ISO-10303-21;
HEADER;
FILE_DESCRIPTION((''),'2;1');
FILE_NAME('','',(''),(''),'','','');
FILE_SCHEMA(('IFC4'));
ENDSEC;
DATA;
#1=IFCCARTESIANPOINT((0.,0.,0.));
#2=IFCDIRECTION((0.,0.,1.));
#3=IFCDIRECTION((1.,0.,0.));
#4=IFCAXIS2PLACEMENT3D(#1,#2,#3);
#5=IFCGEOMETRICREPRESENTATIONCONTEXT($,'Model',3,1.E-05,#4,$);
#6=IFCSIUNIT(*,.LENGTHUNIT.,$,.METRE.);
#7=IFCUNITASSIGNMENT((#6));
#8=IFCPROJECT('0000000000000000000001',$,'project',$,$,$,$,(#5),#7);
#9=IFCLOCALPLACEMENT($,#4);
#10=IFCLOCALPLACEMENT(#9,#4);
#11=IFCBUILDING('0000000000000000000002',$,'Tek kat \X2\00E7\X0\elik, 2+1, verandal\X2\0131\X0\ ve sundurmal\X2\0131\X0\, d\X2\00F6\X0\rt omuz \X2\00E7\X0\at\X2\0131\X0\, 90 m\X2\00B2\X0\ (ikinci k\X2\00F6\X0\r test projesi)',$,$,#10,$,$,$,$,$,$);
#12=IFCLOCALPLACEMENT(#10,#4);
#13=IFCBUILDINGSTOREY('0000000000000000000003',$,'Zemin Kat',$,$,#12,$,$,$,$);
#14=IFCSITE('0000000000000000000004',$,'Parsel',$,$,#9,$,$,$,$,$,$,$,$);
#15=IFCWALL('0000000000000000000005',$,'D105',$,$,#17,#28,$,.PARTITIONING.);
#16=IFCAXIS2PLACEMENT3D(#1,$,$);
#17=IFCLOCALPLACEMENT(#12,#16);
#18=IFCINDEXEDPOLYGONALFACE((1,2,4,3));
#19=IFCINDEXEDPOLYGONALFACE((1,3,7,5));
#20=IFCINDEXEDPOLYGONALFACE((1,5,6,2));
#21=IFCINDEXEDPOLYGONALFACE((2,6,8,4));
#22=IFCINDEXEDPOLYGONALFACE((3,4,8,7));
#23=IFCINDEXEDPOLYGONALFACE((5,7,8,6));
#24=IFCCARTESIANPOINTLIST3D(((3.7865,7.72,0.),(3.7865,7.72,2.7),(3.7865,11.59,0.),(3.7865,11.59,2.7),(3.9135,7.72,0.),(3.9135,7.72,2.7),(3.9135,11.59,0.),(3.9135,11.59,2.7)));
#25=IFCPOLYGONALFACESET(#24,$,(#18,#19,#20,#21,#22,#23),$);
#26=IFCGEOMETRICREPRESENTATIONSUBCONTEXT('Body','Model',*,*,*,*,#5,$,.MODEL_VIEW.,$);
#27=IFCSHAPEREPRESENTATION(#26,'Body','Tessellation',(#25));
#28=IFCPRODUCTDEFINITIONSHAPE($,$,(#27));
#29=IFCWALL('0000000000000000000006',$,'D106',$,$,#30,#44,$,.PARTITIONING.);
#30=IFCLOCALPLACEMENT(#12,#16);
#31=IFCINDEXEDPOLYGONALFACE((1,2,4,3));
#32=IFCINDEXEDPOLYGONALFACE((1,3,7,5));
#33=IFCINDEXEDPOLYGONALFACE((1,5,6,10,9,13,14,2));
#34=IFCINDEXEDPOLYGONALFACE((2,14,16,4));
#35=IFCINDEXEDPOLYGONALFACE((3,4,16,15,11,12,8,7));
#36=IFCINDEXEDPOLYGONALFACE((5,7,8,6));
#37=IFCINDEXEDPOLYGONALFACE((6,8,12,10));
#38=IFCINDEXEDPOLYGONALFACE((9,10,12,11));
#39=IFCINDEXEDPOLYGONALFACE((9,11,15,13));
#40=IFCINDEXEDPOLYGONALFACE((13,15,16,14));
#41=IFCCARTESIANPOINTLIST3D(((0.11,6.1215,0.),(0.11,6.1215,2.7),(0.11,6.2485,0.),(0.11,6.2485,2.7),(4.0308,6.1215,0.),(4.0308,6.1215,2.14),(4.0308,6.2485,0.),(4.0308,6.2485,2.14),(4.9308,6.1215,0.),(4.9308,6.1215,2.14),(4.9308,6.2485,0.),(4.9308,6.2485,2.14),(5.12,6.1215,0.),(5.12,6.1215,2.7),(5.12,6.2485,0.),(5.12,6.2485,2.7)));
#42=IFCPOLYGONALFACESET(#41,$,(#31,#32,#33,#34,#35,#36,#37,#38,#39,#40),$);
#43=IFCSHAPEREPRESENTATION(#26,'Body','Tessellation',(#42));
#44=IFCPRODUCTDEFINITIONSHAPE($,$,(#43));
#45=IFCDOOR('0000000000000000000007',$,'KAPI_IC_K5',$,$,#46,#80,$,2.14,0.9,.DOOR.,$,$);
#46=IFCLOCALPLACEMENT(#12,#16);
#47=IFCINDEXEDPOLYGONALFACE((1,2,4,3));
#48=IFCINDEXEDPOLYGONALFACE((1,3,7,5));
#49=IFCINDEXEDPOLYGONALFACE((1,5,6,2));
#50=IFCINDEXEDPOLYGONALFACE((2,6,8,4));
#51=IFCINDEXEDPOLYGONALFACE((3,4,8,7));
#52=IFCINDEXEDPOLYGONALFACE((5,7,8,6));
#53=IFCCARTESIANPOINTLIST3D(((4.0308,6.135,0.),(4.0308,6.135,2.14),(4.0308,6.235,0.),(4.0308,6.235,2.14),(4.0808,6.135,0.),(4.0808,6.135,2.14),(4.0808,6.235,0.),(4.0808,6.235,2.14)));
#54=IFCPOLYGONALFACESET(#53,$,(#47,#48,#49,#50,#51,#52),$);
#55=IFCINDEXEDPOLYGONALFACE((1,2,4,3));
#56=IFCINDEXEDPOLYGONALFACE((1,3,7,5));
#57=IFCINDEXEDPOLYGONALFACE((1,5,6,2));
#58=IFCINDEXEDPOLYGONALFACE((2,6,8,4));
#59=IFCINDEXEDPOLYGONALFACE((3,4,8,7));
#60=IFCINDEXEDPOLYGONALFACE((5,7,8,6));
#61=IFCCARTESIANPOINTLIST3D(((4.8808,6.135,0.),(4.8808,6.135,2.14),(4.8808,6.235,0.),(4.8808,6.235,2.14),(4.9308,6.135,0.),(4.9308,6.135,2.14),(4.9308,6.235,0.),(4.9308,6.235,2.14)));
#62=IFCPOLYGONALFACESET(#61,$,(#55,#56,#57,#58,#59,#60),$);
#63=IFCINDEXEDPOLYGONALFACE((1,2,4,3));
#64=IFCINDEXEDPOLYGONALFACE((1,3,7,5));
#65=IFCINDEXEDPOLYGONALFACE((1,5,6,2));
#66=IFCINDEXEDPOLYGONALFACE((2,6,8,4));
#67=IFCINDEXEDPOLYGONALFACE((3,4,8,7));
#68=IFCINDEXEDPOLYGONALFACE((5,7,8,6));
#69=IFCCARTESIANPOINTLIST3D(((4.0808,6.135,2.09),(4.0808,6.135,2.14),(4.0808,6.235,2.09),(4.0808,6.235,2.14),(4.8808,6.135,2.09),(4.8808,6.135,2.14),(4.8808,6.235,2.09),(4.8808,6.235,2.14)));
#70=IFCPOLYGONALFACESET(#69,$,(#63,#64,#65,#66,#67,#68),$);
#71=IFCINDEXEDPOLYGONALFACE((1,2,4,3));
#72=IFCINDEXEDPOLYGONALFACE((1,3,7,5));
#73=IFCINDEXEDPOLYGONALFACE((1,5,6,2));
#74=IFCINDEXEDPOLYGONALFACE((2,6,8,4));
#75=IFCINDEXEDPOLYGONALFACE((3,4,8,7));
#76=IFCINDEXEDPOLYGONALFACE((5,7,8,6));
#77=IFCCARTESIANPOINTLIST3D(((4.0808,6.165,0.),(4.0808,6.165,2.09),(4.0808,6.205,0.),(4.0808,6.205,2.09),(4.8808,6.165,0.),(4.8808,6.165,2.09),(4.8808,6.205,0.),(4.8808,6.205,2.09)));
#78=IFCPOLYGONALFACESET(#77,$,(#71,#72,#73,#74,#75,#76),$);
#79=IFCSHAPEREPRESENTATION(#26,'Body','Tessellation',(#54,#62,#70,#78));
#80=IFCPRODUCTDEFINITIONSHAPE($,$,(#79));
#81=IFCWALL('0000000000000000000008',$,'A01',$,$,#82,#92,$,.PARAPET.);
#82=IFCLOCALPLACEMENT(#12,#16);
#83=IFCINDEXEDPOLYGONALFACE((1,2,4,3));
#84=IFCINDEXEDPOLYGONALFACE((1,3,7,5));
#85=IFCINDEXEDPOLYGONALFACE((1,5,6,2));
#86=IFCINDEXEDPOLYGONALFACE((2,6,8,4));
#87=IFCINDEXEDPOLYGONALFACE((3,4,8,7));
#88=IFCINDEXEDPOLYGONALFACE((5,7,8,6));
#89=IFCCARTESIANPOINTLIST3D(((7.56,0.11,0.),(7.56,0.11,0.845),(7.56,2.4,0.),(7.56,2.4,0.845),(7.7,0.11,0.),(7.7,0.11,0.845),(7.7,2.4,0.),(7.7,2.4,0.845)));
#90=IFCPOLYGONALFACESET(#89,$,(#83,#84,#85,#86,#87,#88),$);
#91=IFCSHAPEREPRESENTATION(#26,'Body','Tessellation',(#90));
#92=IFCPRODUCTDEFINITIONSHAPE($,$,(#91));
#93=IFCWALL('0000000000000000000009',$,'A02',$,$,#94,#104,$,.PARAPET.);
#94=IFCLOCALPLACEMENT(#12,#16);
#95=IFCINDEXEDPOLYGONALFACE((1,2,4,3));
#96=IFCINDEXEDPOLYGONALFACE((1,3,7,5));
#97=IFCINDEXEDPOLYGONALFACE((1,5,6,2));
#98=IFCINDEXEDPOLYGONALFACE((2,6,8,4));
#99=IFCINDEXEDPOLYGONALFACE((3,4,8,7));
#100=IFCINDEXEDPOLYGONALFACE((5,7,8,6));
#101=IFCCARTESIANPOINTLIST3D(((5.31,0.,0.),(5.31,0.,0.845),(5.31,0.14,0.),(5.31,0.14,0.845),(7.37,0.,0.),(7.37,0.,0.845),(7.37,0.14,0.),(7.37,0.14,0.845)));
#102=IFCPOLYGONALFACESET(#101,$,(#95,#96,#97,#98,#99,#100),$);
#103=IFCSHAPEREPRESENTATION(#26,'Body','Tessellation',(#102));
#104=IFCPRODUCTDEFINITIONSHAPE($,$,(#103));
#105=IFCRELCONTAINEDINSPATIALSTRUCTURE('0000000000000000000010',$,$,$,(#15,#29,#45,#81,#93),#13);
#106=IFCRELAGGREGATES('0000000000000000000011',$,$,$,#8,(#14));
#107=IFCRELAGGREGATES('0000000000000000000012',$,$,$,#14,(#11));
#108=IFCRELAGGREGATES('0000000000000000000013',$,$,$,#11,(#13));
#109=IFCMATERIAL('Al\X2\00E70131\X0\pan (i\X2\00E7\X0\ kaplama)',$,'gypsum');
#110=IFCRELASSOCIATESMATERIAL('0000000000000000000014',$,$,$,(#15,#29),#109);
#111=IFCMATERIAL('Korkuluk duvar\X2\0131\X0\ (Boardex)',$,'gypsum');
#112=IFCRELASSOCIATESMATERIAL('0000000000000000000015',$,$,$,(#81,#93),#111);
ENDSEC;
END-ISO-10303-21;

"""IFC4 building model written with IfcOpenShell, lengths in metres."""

from ifc_helpers import new_model, si_unit, frame, origin_with_axes, place, context, subcontext, project, spatial, line, indexed_curve, outline, extrude, material, element, fill, save


model = new_model("IFC4")

# Units and contexts
model_context = context("Model", 3, precision=1e-05, world=origin_with_axes())
body_context = subcontext(model_context, "Body", "Model", "MODEL_VIEW")
ifc_project = project(units=[si_unit("LENGTHUNIT", "METRE")], contexts=[model_context])

# Site, building, storey
site_placement = place(None, origin_with_axes())
site = spatial("IfcSite", under=ifc_project, at=site_placement, Name="Parsel")
building_placement = place(site_placement, origin_with_axes())
building = spatial("IfcBuilding", under=site, at=building_placement, Name="Tek kat çelik, 2+1, verandalı ve sundurmalı, dört omuz çatı, 90 m² (ikinci kör test projesi)")
storey_placement = place(building_placement, origin_with_axes())
storey = spatial("IfcBuildingStorey", under=building, at=storey_placement, Name="Zemin Kat")

# Shared definitions
ifc_material_1 = material(Name="Alçıpan (iç kaplama)", Category="gypsum")

# Wall
wall_1_placement = place(storey_placement, origin_with_axes())
element("IfcWall", 1, at=wall_1_placement, inside=storey, material=ifc_material_1, Name="D105", PredefinedType="PARTITIONING", context=body_context, shape_type="SweptSolid", body=[
    extrude(outline(indexed_curve([(0.0, 0.0), (0.127, 0.0), (0.127, 3.87), (0.0, 3.87)], segments=[line(1, 2, 3, 4, 1)])), frame((3.7865, 7.72, 0.0), z_axis=(0.0, 0.0, 1.0), x_axis=(1.0, 0.0, 0.0)), (0.0, 0.0, 1.0), 2.7),
])

# Wall, opening, door
wall_2_placement = place(storey_placement, origin_with_axes())
wall_2 = element("IfcWall", 2, at=wall_2_placement, inside=storey, material=ifc_material_1, Name="D106", PredefinedType="PARTITIONING", context=body_context, shape_type="SweptSolid", body=[
    extrude(outline(indexed_curve([(0.0, 0.0), (5.01, 0.0), (5.01, 0.127), (0.0, 0.127)], segments=[line(1, 2, 3, 4, 1)])), frame((0.11, 6.1215, 0.0), z_axis=(0.0, 0.0, 1.0), x_axis=(1.0, 0.0, 0.0)), (0.0, 0.0, 1.0), 2.7),
])
opening_1_placement = place(wall_2_placement, origin_with_axes())
opening_1 = element("IfcOpeningElement", 3, at=opening_1_placement, cuts=wall_2, PredefinedType="OPENING", context=body_context, shape_type="SweptSolid", body=[
    extrude(outline(indexed_curve([(0.0, 0.0), (0.9, 0.0), (0.9, 0.167), (0.0, 0.167)], segments=[line(1, 2, 3, 4, 1)])), frame((4.0308, 6.1015, 0.0), z_axis=(0.0, 0.0, 1.0), x_axis=(1.0, 0.0, 0.0)), (0.0, 0.0, 1.0), 2.14),
])
door_1_placement = place(storey_placement, origin_with_axes())
door_1 = element("IfcDoor", 4, at=door_1_placement, inside=storey, Name="KAPI_IC_K5", OverallHeight=2.14, OverallWidth=0.9, PredefinedType="DOOR", context=body_context, shape_type="SweptSolid", body=[
    extrude(outline(indexed_curve([(0.0, 0.0), (0.05, 0.0), (0.05, 0.1), (0.0, 0.1)], segments=[line(1, 2, 3, 4, 1)])), frame((4.0308, 6.135, 0.0), z_axis=(0.0, 0.0, 1.0), x_axis=(1.0, 0.0, 0.0)), (0.0, 0.0, 1.0), 2.14),
    extrude(outline(indexed_curve([(0.0, 0.0), (0.05, 0.0), (0.05, 0.1), (0.0, 0.1)], segments=[line(1, 2, 3, 4, 1)])), frame((4.8808, 6.135, 0.0), z_axis=(0.0, 0.0, 1.0), x_axis=(1.0, 0.0, 0.0)), (0.0, 0.0, 1.0), 2.14),
    extrude(outline(indexed_curve([(0.0, 0.0), (0.8, 0.0), (0.8, 0.1), (0.0, 0.1)], segments=[line(1, 2, 3, 4, 1)])), frame((4.0808, 6.135, 2.09), z_axis=(0.0, 0.0, 1.0), x_axis=(1.0, 0.0, 0.0)), (0.0, 0.0, 1.0), 0.05),
    extrude(outline(indexed_curve([(0.0, 0.0), (0.8, 0.0), (0.8, 0.04), (0.0, 0.04)], segments=[line(1, 2, 3, 4, 1)])), frame((4.0808, 6.165, 0.0), z_axis=(0.0, 0.0, 1.0), x_axis=(1.0, 0.0, 0.0)), (0.0, 0.0, 1.0), 2.09),
])
fill(opening_1, door_1)

# Walls
ifc_material_2 = material(Name="Korkuluk duvarı (Boardex)", Category="gypsum")
wall_3_placement = place(storey_placement, origin_with_axes())
element("IfcWall", 5, at=wall_3_placement, inside=storey, material=ifc_material_2, Name="A01", PredefinedType="PARAPET", context=body_context, shape_type="SweptSolid", body=[
    extrude(outline(indexed_curve([(0.0, 0.0), (0.14, 0.0), (0.14, 2.29), (0.0, 2.29)], segments=[line(1, 2, 3, 4, 1)])), frame((7.56, 0.11, 0.0), z_axis=(0.0, 0.0, 1.0), x_axis=(1.0, 0.0, 0.0)), (0.0, 0.0, 1.0), 0.845),
])
wall_4_placement = place(storey_placement, origin_with_axes())
element("IfcWall", 6, at=wall_4_placement, inside=storey, material=ifc_material_2, Name="A02", PredefinedType="PARAPET", context=body_context, shape_type="SweptSolid", body=[
    extrude(outline(indexed_curve([(0.0, 0.0), (2.06, 0.0), (2.06, 0.14), (0.0, 0.14)], segments=[line(1, 2, 3, 4, 1)])), frame((5.31, 0.0, 0.0), z_axis=(0.0, 0.0, 1.0), x_axis=(1.0, 0.0, 0.0)), (0.0, 0.0, 1.0), 0.845),
])

save(model, "model.ifc")
